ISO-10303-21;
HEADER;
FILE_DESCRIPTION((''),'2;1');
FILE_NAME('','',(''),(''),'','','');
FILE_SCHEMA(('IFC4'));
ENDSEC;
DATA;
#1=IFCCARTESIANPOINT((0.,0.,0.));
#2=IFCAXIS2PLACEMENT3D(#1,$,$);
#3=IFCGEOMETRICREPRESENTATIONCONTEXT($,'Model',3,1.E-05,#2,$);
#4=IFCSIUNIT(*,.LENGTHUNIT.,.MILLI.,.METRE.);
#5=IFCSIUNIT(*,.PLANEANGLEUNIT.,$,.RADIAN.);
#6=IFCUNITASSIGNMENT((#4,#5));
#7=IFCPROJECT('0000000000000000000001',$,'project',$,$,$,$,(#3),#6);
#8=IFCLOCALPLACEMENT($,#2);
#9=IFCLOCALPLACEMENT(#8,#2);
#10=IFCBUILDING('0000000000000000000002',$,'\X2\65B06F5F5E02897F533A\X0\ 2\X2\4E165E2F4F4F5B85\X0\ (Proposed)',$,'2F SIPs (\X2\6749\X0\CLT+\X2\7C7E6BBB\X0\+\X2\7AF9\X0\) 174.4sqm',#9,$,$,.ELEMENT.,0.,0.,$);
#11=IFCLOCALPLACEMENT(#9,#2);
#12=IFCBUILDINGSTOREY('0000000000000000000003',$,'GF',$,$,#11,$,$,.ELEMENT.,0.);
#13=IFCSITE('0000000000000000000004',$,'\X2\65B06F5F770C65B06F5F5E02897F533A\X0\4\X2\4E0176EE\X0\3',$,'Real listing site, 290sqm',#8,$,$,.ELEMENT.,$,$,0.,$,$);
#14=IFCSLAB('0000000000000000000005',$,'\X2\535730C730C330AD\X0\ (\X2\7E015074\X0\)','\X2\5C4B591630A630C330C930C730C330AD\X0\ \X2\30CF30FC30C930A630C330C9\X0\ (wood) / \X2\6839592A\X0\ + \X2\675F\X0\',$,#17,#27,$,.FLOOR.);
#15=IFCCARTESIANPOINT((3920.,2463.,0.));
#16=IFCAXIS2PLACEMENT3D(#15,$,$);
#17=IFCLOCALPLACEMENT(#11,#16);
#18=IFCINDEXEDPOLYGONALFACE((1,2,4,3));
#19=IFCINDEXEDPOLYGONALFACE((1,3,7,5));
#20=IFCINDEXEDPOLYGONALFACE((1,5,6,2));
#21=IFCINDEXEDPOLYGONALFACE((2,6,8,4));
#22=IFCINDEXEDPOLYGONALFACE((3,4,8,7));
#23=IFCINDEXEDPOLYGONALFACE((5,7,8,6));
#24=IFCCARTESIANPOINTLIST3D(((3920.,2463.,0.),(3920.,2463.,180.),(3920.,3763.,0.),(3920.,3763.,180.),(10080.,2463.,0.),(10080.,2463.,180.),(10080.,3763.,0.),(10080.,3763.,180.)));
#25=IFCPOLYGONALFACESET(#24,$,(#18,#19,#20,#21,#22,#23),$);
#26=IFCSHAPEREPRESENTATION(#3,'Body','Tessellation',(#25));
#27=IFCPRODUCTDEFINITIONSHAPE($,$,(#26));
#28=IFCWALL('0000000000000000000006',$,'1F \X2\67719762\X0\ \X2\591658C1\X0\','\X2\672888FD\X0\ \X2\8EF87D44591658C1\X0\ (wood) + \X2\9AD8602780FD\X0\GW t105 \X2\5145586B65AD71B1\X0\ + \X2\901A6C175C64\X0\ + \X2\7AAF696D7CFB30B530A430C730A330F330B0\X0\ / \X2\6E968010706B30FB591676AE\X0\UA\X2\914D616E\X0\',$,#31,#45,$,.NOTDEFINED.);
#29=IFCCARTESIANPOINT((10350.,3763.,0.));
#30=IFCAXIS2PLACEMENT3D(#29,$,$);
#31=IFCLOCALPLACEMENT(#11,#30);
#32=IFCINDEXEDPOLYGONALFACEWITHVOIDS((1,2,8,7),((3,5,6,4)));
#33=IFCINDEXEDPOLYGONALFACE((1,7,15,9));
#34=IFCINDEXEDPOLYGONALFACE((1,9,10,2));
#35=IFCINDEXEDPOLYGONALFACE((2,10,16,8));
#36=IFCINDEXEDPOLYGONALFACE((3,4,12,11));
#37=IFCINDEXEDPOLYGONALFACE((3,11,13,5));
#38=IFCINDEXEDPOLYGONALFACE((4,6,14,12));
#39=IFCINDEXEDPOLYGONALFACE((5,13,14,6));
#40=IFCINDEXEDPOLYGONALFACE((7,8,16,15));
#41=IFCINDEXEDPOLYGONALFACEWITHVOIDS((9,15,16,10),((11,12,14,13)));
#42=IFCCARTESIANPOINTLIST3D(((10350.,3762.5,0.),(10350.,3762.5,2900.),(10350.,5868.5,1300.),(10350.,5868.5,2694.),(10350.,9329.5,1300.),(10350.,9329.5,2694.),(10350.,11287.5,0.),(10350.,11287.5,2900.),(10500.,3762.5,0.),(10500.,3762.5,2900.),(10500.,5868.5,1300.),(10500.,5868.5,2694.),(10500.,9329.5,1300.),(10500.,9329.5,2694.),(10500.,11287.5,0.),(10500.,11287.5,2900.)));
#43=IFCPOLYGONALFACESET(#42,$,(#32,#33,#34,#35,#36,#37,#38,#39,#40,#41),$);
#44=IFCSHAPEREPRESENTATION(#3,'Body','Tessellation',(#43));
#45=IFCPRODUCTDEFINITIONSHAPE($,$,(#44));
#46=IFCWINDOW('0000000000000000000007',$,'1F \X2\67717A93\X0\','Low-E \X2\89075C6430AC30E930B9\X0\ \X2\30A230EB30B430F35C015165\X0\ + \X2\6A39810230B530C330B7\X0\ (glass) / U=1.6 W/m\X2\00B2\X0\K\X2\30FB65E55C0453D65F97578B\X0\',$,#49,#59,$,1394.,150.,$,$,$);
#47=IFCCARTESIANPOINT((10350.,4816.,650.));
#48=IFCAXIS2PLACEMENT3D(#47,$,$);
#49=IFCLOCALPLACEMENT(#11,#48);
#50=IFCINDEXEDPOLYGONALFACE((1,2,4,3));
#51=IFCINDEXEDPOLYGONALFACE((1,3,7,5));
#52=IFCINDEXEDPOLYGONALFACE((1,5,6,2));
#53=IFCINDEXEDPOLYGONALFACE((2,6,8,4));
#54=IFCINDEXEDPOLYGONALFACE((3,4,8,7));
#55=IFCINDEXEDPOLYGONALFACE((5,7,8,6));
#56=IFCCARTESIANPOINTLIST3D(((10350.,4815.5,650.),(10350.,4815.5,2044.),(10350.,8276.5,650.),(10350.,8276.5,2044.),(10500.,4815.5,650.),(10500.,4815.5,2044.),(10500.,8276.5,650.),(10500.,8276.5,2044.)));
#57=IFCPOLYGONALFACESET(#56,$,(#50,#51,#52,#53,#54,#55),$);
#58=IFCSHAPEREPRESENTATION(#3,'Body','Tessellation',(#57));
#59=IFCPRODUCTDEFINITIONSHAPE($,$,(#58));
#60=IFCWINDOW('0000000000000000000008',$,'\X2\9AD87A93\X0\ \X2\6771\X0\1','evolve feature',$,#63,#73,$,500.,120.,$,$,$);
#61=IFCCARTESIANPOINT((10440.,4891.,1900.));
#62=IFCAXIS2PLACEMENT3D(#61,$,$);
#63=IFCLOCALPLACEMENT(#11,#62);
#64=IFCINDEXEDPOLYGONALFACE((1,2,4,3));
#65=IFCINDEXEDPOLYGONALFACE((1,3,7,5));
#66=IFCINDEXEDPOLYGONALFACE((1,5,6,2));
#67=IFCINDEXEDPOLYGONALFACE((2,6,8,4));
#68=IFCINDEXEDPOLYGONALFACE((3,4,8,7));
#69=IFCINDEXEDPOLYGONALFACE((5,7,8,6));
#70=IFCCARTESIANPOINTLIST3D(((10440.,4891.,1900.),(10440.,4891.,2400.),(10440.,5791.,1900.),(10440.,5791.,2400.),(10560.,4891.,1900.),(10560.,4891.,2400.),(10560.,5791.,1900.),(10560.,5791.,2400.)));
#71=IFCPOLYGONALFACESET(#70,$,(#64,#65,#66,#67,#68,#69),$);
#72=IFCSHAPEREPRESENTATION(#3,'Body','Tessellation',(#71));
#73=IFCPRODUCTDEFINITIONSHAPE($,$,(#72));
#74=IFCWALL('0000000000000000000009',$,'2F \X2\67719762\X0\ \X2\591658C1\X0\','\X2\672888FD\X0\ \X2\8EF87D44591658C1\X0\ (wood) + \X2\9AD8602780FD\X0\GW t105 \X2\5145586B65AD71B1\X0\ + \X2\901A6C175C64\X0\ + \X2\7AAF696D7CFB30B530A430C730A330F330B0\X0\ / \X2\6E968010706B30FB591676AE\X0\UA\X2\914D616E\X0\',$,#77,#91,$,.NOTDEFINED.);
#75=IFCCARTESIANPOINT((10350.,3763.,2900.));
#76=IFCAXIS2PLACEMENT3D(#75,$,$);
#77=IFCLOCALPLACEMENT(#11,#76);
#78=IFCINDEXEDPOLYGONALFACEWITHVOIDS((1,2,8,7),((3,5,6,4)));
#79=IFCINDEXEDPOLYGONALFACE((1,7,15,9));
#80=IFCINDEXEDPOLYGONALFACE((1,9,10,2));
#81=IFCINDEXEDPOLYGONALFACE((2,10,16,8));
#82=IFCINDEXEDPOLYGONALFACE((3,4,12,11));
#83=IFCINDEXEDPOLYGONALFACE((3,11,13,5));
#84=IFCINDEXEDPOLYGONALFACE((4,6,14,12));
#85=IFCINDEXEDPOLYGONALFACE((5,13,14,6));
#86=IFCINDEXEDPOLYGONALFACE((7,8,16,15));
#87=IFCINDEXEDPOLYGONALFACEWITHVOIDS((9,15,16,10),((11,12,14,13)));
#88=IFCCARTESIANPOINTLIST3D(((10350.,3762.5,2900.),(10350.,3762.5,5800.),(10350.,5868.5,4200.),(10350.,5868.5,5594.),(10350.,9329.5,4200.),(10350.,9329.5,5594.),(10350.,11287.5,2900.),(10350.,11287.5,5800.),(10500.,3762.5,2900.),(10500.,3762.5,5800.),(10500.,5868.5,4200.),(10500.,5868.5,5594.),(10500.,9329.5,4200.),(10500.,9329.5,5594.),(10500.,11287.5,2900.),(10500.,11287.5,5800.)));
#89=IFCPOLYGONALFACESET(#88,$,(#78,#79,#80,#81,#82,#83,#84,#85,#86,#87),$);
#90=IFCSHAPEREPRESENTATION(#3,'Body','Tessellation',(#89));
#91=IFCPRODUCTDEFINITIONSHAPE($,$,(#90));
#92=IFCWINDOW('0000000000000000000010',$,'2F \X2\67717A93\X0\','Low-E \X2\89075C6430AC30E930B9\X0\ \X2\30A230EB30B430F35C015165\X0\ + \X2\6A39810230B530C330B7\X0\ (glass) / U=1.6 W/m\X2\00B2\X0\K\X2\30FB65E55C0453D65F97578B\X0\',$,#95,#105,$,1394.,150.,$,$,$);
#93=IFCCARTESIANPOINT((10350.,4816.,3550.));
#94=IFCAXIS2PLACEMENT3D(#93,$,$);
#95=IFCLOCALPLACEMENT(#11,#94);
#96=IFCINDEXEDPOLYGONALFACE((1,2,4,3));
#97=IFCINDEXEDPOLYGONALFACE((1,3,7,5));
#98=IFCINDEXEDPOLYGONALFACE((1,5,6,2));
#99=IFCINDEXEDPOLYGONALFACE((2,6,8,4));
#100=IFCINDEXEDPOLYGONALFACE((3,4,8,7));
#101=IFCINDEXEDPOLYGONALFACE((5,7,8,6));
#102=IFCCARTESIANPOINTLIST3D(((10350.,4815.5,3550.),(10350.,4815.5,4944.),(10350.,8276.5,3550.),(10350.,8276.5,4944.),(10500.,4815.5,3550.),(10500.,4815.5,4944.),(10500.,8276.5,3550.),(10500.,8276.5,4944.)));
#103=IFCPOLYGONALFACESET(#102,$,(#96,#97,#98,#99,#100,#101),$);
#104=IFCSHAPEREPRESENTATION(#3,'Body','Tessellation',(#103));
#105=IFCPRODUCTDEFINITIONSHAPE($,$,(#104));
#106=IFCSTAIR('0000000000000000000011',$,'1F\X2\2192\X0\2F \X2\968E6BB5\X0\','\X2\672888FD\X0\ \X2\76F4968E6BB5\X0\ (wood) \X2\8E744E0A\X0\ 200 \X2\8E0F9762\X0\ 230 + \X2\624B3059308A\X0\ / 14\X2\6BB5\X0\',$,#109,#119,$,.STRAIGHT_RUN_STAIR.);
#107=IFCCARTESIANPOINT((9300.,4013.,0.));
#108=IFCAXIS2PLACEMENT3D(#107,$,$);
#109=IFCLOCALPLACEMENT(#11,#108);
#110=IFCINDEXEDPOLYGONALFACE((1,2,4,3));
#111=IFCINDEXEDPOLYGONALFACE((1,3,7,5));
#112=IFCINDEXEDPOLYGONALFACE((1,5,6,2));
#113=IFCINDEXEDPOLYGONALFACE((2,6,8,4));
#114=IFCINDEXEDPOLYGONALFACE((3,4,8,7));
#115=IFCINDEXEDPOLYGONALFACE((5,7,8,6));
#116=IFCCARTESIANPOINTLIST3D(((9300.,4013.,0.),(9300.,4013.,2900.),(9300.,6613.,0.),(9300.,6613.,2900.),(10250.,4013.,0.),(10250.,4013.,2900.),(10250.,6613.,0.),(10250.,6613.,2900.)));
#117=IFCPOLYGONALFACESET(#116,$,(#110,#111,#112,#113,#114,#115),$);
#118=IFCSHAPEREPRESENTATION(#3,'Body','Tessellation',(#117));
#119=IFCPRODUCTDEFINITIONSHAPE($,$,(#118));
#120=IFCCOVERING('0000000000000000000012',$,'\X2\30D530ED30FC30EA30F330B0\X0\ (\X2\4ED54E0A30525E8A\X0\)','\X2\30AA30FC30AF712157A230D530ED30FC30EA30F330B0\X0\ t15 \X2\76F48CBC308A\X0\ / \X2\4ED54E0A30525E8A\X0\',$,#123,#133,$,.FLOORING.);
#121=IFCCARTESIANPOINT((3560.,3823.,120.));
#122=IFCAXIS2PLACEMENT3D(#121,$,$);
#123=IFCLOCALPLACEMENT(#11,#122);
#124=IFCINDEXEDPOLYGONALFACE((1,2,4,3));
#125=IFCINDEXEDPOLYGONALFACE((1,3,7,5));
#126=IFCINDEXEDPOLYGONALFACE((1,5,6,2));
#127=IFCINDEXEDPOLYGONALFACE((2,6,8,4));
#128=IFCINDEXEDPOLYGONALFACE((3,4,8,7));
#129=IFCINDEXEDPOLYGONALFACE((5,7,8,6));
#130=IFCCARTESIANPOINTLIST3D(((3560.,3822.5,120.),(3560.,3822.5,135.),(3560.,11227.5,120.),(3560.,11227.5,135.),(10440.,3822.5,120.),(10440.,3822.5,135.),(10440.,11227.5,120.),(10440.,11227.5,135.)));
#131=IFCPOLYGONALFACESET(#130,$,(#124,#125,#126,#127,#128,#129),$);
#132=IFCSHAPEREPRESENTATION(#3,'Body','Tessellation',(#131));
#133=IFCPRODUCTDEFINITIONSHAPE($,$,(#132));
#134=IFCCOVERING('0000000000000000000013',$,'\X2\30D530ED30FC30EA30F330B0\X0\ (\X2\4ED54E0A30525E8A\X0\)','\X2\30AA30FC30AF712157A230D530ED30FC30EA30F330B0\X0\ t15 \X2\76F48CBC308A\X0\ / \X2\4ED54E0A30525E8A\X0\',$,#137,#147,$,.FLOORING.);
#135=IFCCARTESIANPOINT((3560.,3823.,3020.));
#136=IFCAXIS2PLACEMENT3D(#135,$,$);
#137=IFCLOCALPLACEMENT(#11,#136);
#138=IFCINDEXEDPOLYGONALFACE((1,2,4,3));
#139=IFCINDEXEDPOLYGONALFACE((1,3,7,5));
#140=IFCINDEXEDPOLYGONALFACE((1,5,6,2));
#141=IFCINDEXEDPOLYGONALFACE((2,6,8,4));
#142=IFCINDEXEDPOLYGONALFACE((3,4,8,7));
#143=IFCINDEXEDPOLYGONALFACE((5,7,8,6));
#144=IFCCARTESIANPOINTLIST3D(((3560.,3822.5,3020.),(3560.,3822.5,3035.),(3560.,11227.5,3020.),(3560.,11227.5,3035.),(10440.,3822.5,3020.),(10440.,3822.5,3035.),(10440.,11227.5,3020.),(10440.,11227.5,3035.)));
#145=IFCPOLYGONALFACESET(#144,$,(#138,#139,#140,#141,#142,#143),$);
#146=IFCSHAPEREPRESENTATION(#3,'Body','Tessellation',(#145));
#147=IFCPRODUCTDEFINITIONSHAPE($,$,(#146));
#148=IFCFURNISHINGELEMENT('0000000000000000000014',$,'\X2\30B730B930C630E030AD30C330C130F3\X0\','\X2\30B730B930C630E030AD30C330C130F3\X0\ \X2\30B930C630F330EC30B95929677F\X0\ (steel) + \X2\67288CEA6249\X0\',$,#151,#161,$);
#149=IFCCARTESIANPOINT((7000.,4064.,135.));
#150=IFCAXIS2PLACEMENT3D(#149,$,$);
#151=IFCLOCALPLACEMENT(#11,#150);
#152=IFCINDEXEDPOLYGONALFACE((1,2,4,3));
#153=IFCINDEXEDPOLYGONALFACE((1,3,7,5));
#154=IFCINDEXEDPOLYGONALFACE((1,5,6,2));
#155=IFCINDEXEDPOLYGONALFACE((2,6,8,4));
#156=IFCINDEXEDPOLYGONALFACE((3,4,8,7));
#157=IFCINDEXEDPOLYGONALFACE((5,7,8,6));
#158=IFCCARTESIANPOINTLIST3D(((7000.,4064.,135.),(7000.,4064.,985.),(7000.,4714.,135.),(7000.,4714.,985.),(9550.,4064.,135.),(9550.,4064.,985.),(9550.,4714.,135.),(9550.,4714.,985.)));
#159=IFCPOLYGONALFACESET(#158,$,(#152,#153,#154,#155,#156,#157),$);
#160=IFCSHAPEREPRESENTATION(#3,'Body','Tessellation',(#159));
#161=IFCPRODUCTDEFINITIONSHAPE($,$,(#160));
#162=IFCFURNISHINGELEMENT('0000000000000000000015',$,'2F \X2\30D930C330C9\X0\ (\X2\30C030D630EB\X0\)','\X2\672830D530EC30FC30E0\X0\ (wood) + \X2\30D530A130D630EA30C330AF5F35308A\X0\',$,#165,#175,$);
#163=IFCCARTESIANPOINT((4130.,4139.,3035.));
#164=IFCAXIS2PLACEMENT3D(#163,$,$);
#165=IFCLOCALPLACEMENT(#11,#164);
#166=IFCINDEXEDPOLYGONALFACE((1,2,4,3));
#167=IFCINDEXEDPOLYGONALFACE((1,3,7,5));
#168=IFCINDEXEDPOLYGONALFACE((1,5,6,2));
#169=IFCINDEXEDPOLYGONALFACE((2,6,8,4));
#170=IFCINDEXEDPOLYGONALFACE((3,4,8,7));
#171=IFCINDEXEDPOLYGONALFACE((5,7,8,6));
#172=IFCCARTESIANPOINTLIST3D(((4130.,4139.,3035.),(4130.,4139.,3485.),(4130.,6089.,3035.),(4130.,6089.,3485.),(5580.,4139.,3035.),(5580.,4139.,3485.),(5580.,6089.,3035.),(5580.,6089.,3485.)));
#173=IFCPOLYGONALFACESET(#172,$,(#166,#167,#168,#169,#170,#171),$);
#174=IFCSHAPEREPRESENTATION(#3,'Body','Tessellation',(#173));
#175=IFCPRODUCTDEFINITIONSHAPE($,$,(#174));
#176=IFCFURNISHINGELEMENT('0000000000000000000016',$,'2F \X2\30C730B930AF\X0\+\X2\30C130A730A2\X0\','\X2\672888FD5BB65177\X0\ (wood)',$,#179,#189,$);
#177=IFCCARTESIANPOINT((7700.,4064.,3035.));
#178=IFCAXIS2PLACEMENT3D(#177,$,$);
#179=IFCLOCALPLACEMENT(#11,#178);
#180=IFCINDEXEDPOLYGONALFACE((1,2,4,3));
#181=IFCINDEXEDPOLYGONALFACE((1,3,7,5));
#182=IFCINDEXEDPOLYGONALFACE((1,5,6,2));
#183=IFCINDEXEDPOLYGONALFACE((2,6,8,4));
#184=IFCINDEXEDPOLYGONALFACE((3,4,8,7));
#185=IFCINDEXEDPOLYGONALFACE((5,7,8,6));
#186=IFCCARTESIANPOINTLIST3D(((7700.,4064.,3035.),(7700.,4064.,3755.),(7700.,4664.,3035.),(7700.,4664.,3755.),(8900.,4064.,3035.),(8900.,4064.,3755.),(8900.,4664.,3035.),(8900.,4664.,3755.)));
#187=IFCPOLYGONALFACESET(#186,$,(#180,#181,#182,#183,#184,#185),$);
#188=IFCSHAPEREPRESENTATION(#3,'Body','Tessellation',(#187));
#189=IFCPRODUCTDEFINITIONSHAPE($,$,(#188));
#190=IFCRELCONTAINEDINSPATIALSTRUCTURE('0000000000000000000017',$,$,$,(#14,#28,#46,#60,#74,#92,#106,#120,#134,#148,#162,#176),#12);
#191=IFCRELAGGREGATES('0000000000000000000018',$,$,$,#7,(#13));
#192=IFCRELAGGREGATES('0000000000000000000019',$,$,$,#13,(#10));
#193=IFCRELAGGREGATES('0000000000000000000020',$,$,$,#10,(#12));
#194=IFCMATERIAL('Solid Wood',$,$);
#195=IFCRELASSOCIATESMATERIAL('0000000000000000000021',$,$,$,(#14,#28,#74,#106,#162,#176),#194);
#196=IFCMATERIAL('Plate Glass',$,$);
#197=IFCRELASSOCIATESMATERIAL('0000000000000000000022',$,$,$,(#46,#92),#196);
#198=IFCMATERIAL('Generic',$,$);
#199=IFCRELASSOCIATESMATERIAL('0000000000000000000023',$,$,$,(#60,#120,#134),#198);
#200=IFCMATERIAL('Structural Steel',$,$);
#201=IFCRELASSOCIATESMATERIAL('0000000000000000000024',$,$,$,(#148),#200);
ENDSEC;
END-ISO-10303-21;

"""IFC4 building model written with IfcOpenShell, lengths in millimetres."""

from ifc_helpers import new_model, si_unit, frame, frame_2d, origin, place, context, project, spatial, rectangle, extrude, material, element, fill, save


model = new_model("IFC4")

# Units and contexts
model_context = context("Model", 3, precision=1e-05, world=origin())
ifc_project = project(units=[si_unit("LENGTHUNIT", "METRE", prefix="MILLI"), si_unit("PLANEANGLEUNIT", "RADIAN")], contexts=[model_context])

# Site, building, storey
site_placement = place(None, origin())
site = spatial("IfcSite", under=ifc_project, at=site_placement, Name="新潟県新潟市西区4丁目3", ObjectType="Real listing site, 290sqm", CompositionType="ELEMENT", RefElevation=0.0)
building_placement = place(site_placement, origin())
building = spatial("IfcBuilding", under=site, at=building_placement, Name="新潟市西区 2世帯住宅 (Proposed)", ObjectType="2F SIPs (杉CLT+籾殻+竹) 174.4sqm", CompositionType="ELEMENT", ElevationOfRefHeight=0.0, ElevationOfTerrain=0.0)
storey_placement = place(building_placement, origin())
storey = spatial("IfcBuildingStorey", under=building, at=storey_placement, Name="GF", CompositionType="ELEMENT", Elevation=0.0)

# Slab
ifc_material_1 = material(Name="Solid Wood")
slab_placement = place(storey_placement, frame((3920.0, 2463.0, 0.0)))
element("IfcSlab", 1, at=slab_placement, inside=storey, material=ifc_material_1, Name="南デッキ (縁側)", Description="屋外ウッドデッキ ハードウッド (wood) / 根太 + 束", PredefinedType="FLOOR", context=model_context, shape_type="SweptSolid", body=[
    extrude(rectangle(XDim=6160.0, YDim=1300.0, at=frame_2d((3080.0, 650.0))), frame((3920.0, 2463.0, 0.0)), (0.0, 0.0, 1.0), 180.0),
])

# Wall, openings, windows
wall_1_placement = place(storey_placement, frame((10350.0, 3763.0, 0.0)))
wall_1 = element("IfcWall", 2, at=wall_1_placement, inside=storey, material=ifc_material_1, Name="1F 東面 外壁", Description="木製 軸組外壁 (wood) + 高性能GW t105 充填断熱 + 通気層 + 窯業系サイディング / 準耐火・外皮UA配慮", PredefinedType="NOTDEFINED", context=model_context, shape_type="SweptSolid", body=[
    extrude(rectangle(XDim=150.0, YDim=7525.0, at=frame_2d((75.0, 3762.0))), frame((10350.0, 3763.0, 0.0)), (0.0, 0.0, 1.0), 2900.0),
])
opening_1_placement = place(storey_placement, frame((10350.0, 4816.0, 650.0)))
opening_1 = element("IfcOpeningElement", 3, at=opening_1_placement, cuts=wall_1, PredefinedType="NOTDEFINED", context=model_context, shape_type="SweptSolid", body=[
    extrude(rectangle(XDim=150.0, YDim=3461.0, at=frame_2d((75.0, 1730.0))), frame((10350.0, 4816.0, 650.0)), (0.0, 0.0, 1.0), 1394.0),
])
opening_2_placement = place(storey_placement, frame((10440.0, 4891.0, 1900.0)))
opening_2 = element("IfcOpeningElement", 4, at=opening_2_placement, cuts=wall_1, PredefinedType="NOTDEFINED", context=model_context, shape_type="SweptSolid", body=[
    extrude(rectangle(XDim=120.0, YDim=900.0, at=frame_2d((60.0, 450.0))), frame((10440.0, 4891.0, 1900.0)), (0.0, 0.0, 1.0), 500.0),
])
ifc_material_2 = material(Name="Plate Glass")
window_1_placement = place(storey_placement, frame((10350.0, 4816.0, 650.0)))
window_1 = element("IfcWindow", 5, at=window_1_placement, inside=storey, material=ifc_material_2, Name="1F 東窓", Description="Low-E 複層ガラス アルゴン封入 + 樹脂サッシ (glass) / U=1.6 W/m²K・日射取得型", OverallHeight=1394.0, OverallWidth=150.0, context=model_context, shape_type="SweptSolid", body=[
    extrude(rectangle(XDim=150.0, YDim=3461.0, at=frame_2d((75.0, 1730.0))), frame((10350.0, 4816.0, 650.0)), (0.0, 0.0, 1.0), 1394.0),
])
fill(opening_1, window_1)
ifc_material_3 = material(Name="Generic")
window_2_placement = place(storey_placement, frame((10440.0, 4891.0, 1900.0)))
window_2 = element("IfcWindow", 6, at=window_2_placement, inside=storey, material=ifc_material_3, Name="高窓 東1", Description="evolve feature", OverallHeight=500.0, OverallWidth=120.0, context=model_context, shape_type="SweptSolid", body=[
    extrude(rectangle(XDim=120.0, YDim=900.0, at=frame_2d((60.0, 450.0))), frame((10440.0, 4891.0, 1900.0)), (0.0, 0.0, 1.0), 500.0),
])
fill(opening_2, window_2)

# Wall, opening, window
wall_2_placement = place(storey_placement, frame((10350.0, 3763.0, 2900.0)))
wall_2 = element("IfcWall", 7, at=wall_2_placement, inside=storey, material=ifc_material_1, Name="2F 東面 外壁", Description="木製 軸組外壁 (wood) + 高性能GW t105 充填断熱 + 通気層 + 窯業系サイディング / 準耐火・外皮UA配慮", PredefinedType="NOTDEFINED", context=model_context, shape_type="SweptSolid", body=[
    extrude(rectangle(XDim=150.0, YDim=7525.0, at=frame_2d((75.0, 3762.0))), frame((10350.0, 3763.0, 2900.0)), (0.0, 0.0, 1.0), 2900.0),
])
opening_3_placement = place(storey_placement, frame((10350.0, 4816.0, 3550.0)))
opening_3 = element("IfcOpeningElement", 8, at=opening_3_placement, cuts=wall_2, PredefinedType="NOTDEFINED", context=model_context, shape_type="SweptSolid", body=[
    extrude(rectangle(XDim=150.0, YDim=3461.0, at=frame_2d((75.0, 1730.0))), frame((10350.0, 4816.0, 3550.0)), (0.0, 0.0, 1.0), 1394.0),
])
window_3_placement = place(storey_placement, frame((10350.0, 4816.0, 3550.0)))
window_3 = element("IfcWindow", 9, at=window_3_placement, inside=storey, material=ifc_material_2, Name="2F 東窓", Description="Low-E 複層ガラス アルゴン封入 + 樹脂サッシ (glass) / U=1.6 W/m²K・日射取得型", OverallHeight=1394.0, OverallWidth=150.0, context=model_context, shape_type="SweptSolid", body=[
    extrude(rectangle(XDim=150.0, YDim=3461.0, at=frame_2d((75.0, 1730.0))), frame((10350.0, 4816.0, 3550.0)), (0.0, 0.0, 1.0), 1394.0),
])
fill(opening_3, window_3)

# Stair
stair_placement = place(storey_placement, frame((9300.0, 4013.0, 0.0)))
element("IfcStair", 10, at=stair_placement, inside=storey, material=ifc_material_1, Name="1F→2F 階段", Description="木製 直階段 (wood) 蹴上 200 踏面 230 + 手すり / 14段", PredefinedType="STRAIGHT_RUN_STAIR", context=model_context, shape_type="SweptSolid", body=[
    extrude(rectangle(XDim=950.0, YDim=2600.0, at=frame_2d((475.0, 1300.0))), frame((9300.0, 4013.0, 0.0)), (0.0, 0.0, 1.0), 2900.0),
])

# Coverings
covering_1_placement = place(storey_placement, frame((3560.0, 3823.0, 120.0)))
element("IfcCovering", 11, at=covering_1_placement, inside=storey, material=ifc_material_3, Name="フローリング (仕上げ床)", Description="オーク無垢フローリング t15 直貼り / 仕上げ床", PredefinedType="FLOORING", context=model_context, shape_type="SweptSolid", body=[
    extrude(rectangle(XDim=6880.0, YDim=7405.0, at=frame_2d((3440.0, 3702.0))), frame((3560.0, 3823.0, 120.0)), (0.0, 0.0, 1.0), 15.0),
])
covering_2_placement = place(storey_placement, frame((3560.0, 3823.0, 3020.0)))
element("IfcCovering", 12, at=covering_2_placement, inside=storey, material=ifc_material_3, Name="フローリング (仕上げ床)", Description="オーク無垢フローリング t15 直貼り / 仕上げ床", PredefinedType="FLOORING", context=model_context, shape_type="SweptSolid", body=[
    extrude(rectangle(XDim=6880.0, YDim=7405.0, at=frame_2d((3440.0, 3702.0))), frame((3560.0, 3823.0, 3020.0)), (0.0, 0.0, 1.0), 15.0),
])

# Furnishing elements
ifc_material_4 = material(Name="Structural Steel")
furnishing_1_placement = place(storey_placement, frame((7000.0, 4064.0, 135.0)))
element("IfcFurnishingElement", 13, at=furnishing_1_placement, inside=storey, material=ifc_material_4, Name="システムキッチン", Description="システムキッチン ステンレス天板 (steel) + 木質扉", context=model_context, shape_type="SweptSolid", body=[
    extrude(rectangle(XDim=2550.0, YDim=650.0, at=frame_2d((1275.0, 325.0))), frame((7000.0, 4064.0, 135.0)), (0.0, 0.0, 1.0), 850.0),
])
furnishing_2_placement = place(storey_placement, frame((4130.0, 4139.0, 3035.0)))
element("IfcFurnishingElement", 14, at=furnishing_2_placement, inside=storey, material=ifc_material_1, Name="2F ベッド (ダブル)", Description="木フレーム (wood) + ファブリック張り", context=model_context, shape_type="SweptSolid", body=[
    extrude(rectangle(XDim=1450.0, YDim=1950.0, at=frame_2d((725.0, 975.0))), frame((4130.0, 4139.0, 3035.0)), (0.0, 0.0, 1.0), 450.0),
])
furnishing_3_placement = place(storey_placement, frame((7700.0, 4064.0, 3035.0)))
element("IfcFurnishingElement", 15, at=furnishing_3_placement, inside=storey, material=ifc_material_1, Name="2F デスク+チェア", Description="木製家具 (wood)", context=model_context, shape_type="SweptSolid", body=[
    extrude(rectangle(XDim=1200.0, YDim=600.0, at=frame_2d((600.0, 300.0))), frame((7700.0, 4064.0, 3035.0)), (0.0, 0.0, 1.0), 720.0),
])

save(model, "model.ifc")
